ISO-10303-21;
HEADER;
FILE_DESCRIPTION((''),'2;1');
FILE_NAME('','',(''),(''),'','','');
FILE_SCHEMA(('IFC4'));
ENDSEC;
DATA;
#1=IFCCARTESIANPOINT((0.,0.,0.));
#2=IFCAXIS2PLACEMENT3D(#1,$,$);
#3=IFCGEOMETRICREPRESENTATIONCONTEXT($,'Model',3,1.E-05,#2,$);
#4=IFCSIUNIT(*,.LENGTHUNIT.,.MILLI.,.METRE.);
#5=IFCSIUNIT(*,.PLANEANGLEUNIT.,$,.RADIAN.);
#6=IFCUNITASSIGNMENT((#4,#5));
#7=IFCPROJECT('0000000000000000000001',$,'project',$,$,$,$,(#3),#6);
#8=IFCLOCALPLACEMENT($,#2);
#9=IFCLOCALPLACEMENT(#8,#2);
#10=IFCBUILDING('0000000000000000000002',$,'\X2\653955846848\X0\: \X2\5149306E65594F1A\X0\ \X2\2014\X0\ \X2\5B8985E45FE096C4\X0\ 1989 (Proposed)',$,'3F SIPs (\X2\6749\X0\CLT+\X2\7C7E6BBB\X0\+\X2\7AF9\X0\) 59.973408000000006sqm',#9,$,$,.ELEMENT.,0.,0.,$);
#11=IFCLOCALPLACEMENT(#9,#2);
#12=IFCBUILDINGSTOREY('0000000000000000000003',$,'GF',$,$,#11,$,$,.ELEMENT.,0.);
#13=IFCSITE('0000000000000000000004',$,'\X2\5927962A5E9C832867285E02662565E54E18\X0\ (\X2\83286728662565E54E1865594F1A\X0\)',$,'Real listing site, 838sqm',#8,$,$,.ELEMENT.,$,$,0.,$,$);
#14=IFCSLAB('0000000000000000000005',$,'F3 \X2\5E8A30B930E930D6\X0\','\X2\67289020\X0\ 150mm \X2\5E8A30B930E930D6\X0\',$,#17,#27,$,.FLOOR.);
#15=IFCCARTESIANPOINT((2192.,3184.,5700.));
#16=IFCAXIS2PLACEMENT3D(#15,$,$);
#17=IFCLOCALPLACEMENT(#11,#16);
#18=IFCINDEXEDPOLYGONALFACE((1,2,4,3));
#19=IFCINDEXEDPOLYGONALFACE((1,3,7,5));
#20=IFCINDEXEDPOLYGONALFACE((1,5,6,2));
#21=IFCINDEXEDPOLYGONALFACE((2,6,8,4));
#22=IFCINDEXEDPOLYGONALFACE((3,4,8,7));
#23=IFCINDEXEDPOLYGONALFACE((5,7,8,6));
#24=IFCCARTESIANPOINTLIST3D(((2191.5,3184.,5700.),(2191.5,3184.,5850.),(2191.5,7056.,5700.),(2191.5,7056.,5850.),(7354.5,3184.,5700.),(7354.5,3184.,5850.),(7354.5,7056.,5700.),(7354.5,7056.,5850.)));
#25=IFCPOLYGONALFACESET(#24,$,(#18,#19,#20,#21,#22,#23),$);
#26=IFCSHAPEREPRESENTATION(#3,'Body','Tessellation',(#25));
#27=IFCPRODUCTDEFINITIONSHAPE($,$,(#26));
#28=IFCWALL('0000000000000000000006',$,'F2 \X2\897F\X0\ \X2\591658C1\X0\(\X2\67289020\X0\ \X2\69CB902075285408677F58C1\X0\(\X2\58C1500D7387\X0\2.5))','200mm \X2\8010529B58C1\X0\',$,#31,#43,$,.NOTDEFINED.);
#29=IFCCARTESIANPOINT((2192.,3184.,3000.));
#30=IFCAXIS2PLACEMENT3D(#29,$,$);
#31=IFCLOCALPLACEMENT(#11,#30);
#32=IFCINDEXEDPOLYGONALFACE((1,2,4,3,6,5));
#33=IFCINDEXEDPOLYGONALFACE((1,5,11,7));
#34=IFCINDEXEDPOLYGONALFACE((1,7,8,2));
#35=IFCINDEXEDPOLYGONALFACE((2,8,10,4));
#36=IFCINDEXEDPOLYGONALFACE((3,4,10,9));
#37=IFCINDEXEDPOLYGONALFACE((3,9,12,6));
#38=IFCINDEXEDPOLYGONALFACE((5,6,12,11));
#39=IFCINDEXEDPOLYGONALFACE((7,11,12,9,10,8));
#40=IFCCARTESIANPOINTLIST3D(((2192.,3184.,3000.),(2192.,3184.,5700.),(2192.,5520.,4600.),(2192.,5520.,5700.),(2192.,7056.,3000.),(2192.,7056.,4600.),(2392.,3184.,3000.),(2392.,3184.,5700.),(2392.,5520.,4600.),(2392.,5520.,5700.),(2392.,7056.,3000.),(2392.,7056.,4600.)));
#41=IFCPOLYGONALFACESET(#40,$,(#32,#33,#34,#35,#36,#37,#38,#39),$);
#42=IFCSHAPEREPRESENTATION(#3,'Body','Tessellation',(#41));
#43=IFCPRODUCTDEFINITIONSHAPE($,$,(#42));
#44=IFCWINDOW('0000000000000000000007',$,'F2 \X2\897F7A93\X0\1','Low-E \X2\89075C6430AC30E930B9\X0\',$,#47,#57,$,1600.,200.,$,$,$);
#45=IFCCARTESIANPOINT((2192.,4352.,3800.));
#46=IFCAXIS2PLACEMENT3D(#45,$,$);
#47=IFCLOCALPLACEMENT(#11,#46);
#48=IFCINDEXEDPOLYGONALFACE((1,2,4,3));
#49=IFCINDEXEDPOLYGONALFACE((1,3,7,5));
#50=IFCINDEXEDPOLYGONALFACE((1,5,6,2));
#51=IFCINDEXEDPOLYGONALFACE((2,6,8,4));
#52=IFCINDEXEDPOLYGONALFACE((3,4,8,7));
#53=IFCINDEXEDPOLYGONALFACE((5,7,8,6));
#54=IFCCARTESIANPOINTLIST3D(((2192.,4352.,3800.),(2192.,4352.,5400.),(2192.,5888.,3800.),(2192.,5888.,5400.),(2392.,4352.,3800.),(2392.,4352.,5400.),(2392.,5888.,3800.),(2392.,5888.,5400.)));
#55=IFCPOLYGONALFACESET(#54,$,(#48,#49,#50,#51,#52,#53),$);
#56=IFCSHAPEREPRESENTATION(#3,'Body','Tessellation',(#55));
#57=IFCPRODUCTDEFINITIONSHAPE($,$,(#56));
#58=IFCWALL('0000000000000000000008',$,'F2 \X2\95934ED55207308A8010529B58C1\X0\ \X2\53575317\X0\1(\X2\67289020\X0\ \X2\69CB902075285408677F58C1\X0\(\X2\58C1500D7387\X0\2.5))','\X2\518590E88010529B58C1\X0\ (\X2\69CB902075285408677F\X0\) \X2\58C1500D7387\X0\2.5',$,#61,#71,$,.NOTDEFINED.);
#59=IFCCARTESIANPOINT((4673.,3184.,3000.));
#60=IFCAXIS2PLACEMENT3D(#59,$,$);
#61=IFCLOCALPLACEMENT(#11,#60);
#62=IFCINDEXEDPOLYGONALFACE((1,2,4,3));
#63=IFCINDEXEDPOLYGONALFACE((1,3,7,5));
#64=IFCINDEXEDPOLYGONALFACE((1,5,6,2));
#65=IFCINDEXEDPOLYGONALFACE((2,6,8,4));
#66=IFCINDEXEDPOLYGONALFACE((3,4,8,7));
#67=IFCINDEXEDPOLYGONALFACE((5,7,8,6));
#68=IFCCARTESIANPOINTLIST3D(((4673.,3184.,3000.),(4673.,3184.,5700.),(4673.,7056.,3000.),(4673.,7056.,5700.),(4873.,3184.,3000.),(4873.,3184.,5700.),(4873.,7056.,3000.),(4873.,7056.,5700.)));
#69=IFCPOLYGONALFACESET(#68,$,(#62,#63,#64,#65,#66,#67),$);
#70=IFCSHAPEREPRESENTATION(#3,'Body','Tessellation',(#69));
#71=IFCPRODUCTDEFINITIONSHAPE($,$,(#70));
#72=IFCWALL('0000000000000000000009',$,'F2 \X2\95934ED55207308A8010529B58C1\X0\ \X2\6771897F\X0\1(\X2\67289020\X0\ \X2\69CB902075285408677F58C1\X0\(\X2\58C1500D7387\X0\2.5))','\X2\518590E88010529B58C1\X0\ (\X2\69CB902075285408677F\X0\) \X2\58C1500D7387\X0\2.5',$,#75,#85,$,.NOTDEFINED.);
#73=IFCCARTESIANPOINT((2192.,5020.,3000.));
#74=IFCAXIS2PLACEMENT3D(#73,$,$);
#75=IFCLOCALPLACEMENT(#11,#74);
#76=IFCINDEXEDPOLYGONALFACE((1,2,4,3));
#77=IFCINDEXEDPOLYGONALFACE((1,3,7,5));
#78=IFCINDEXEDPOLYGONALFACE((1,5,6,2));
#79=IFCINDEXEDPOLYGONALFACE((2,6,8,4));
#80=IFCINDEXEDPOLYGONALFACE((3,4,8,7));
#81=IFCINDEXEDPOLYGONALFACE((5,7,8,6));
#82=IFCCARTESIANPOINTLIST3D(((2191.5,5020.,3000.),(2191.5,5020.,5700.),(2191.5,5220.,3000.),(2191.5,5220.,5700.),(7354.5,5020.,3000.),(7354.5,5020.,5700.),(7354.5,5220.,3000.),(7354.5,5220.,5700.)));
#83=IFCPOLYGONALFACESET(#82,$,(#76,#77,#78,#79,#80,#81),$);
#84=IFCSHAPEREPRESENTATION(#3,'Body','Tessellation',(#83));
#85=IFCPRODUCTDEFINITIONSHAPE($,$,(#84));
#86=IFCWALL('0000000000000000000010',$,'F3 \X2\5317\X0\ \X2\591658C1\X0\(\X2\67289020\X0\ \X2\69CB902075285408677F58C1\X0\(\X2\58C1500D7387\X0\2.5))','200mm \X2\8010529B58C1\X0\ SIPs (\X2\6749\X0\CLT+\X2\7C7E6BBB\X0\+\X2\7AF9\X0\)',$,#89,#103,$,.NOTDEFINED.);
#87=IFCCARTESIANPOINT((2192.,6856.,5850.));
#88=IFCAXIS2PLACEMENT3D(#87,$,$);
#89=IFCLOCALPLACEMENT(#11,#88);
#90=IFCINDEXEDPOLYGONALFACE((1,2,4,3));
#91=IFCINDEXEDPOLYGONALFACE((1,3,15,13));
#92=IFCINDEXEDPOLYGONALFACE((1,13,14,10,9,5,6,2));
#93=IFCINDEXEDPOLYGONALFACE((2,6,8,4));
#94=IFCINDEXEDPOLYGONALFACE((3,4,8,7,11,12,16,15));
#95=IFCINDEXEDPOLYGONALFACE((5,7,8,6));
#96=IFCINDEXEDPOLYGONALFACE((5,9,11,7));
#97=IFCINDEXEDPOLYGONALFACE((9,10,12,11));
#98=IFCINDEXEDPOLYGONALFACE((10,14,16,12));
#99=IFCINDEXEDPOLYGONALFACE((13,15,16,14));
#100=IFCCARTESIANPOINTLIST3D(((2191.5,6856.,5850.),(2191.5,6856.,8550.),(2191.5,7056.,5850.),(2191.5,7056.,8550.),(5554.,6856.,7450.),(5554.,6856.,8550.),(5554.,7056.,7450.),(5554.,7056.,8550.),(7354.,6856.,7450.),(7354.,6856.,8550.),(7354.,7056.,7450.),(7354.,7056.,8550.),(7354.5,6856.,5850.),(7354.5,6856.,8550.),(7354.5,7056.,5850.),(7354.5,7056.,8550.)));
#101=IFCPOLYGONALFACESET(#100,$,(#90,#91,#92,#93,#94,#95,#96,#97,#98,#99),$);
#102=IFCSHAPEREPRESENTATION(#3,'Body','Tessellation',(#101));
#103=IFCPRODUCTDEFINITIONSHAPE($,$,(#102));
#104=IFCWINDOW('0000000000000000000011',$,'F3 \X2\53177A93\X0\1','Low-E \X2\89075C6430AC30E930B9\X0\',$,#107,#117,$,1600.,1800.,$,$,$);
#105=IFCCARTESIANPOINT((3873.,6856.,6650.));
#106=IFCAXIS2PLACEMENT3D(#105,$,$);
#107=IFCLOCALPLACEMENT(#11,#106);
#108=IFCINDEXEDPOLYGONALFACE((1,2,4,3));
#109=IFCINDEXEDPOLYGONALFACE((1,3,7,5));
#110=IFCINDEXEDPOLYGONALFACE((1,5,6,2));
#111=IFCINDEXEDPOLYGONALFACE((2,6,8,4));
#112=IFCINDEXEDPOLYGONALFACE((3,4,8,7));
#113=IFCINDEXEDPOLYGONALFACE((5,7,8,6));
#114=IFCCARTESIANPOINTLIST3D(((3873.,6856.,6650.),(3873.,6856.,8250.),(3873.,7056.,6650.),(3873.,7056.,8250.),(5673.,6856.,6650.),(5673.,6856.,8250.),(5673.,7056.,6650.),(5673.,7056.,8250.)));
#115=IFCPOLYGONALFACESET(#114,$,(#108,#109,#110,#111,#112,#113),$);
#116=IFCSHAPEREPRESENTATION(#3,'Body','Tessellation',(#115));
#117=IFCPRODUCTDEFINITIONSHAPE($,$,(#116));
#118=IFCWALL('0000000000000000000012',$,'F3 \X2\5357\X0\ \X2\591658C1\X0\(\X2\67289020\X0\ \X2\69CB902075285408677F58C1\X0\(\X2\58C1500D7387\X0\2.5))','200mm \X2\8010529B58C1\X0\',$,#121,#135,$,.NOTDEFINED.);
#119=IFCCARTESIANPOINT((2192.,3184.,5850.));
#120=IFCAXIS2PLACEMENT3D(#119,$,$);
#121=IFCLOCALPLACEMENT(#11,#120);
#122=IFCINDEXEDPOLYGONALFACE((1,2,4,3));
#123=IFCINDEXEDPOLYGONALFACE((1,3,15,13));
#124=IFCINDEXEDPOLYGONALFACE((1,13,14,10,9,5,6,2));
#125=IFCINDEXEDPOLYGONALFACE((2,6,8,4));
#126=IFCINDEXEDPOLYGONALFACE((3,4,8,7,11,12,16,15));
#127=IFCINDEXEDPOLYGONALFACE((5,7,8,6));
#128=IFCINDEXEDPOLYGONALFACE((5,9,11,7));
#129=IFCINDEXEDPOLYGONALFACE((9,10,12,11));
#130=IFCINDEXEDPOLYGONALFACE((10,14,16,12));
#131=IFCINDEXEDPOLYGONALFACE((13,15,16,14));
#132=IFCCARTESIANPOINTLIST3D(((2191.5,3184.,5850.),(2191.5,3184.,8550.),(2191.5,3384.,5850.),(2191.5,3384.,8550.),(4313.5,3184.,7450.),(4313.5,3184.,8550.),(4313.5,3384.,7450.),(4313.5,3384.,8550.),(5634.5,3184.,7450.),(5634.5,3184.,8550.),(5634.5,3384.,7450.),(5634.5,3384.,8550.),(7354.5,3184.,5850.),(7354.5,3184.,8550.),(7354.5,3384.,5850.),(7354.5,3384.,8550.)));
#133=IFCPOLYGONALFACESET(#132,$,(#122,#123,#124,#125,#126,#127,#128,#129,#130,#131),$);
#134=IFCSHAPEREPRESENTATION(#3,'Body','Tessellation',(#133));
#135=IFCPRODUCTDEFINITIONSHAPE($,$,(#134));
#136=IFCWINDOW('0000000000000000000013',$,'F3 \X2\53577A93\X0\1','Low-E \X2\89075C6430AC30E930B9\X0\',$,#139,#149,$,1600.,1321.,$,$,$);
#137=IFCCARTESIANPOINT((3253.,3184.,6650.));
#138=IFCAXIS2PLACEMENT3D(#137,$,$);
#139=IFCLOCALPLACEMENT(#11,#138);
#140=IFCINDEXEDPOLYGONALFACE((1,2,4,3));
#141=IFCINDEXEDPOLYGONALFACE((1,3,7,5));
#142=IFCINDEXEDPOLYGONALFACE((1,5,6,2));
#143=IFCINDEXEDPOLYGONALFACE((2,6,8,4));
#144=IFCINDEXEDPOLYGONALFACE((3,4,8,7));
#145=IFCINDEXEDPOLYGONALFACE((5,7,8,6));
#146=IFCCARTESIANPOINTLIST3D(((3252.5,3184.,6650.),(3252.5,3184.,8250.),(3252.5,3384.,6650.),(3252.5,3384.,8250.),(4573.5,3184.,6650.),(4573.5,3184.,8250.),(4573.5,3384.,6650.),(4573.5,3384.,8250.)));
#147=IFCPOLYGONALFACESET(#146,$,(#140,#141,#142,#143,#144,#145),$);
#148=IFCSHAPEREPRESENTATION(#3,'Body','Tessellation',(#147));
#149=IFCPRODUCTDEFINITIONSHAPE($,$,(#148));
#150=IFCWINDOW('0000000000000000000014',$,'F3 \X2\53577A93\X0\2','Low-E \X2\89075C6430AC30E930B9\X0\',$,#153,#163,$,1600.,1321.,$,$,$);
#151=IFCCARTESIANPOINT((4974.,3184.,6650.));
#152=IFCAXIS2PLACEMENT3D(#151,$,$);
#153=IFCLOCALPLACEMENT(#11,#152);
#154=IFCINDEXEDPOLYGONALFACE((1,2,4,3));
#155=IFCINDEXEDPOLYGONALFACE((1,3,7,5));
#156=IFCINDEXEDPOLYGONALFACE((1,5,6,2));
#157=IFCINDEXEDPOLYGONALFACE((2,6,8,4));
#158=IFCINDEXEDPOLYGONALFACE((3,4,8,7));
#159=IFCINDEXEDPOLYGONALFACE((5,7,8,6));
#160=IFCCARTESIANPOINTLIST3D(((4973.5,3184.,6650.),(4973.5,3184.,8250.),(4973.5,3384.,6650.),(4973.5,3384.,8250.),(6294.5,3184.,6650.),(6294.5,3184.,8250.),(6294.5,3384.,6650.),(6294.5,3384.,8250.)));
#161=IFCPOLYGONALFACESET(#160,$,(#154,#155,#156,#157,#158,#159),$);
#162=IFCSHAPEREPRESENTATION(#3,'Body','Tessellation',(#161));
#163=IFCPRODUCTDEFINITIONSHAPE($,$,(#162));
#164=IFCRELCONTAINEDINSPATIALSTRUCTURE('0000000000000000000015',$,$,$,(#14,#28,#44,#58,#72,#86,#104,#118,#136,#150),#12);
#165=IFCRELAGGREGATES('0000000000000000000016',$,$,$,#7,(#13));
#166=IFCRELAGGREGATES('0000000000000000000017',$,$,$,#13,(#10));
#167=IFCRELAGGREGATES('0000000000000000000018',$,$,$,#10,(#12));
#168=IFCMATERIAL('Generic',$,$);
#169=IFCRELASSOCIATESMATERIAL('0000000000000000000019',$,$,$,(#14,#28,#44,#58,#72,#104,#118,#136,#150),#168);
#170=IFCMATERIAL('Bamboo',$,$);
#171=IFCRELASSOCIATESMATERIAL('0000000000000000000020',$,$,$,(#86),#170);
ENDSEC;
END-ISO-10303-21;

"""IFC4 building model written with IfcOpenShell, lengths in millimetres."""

from ifc_helpers import new_model, si_unit, frame, frame_2d, origin, place, context, project, spatial, rectangle, extrude, material, element, fill, save


model = new_model("IFC4")

# Units and contexts
model_context = context("Model", 3, precision=1e-05, world=origin())
ifc_project = project(units=[si_unit("LENGTHUNIT", "METRE", prefix="MILLI"), si_unit("PLANEANGLEUNIT", "RADIAN")], contexts=[model_context])

# Site, building, storey
site_placement = place(None, origin())
site = spatial("IfcSite", under=ifc_project, at=site_placement, Name="大阪府茨木市春日丘 (茨木春日丘教会)", ObjectType="Real listing site, 838sqm", CompositionType="ELEMENT", RefElevation=0.0)
building_placement = place(site_placement, origin())
building = spatial("IfcBuilding", under=site, at=building_placement, Name="改善案: 光の教会 — 安藤忠雄 1989 (Proposed)", ObjectType="3F SIPs (杉CLT+籾殻+竹) 59.973408000000006sqm", CompositionType="ELEMENT", ElevationOfRefHeight=0.0, ElevationOfTerrain=0.0)
storey_placement = place(building_placement, origin())
storey = spatial("IfcBuildingStorey", under=building, at=storey_placement, Name="GF", CompositionType="ELEMENT", Elevation=0.0)

# Slab
ifc_material_1 = material(Name="Generic")
slab_placement = place(storey_placement, frame((2192.0, 3184.0, 5700.0)))
element("IfcSlab", 1, at=slab_placement, inside=storey, material=ifc_material_1, Name="F3 床スラブ", Description="木造 150mm 床スラブ", PredefinedType="FLOOR", context=model_context, shape_type="SweptSolid", body=[
    extrude(rectangle(XDim=5163.0, YDim=3872.0, at=frame_2d((2581.0, 1936.0))), frame((2192.0, 3184.0, 5700.0)), (0.0, 0.0, 1.0), 150.0),
])

# Wall, opening, window
wall_1_placement = place(storey_placement, frame((2192.0, 3184.0, 3000.0)))
wall_1 = element("IfcWall", 2, at=wall_1_placement, inside=storey, material=ifc_material_1, Name="F2 西 外壁(木造 構造用合板壁(壁倍率2.5))", Description="200mm 耐力壁", PredefinedType="NOTDEFINED", context=model_context, shape_type="SweptSolid", body=[
    extrude(rectangle(XDim=200.0, YDim=3872.0, at=frame_2d((100.0, 1936.0))), frame((2192.0, 3184.0, 3000.0)), (0.0, 0.0, 1.0), 2700.0),
])
opening_1_placement = place(storey_placement, frame((2192.0, 4352.0, 3800.0)))
opening_1 = element("IfcOpeningElement", 3, at=opening_1_placement, cuts=wall_1, PredefinedType="NOTDEFINED", context=model_context, shape_type="SweptSolid", body=[
    extrude(rectangle(XDim=200.0, YDim=1536.0, at=frame_2d((100.0, 768.0))), frame((2192.0, 4352.0, 3800.0)), (0.0, 0.0, 1.0), 1600.0),
])
window_1_placement = place(storey_placement, frame((2192.0, 4352.0, 3800.0)))
window_1 = element("IfcWindow", 4, at=window_1_placement, inside=storey, material=ifc_material_1, Name="F2 西窓1", Description="Low-E 複層ガラス", OverallHeight=1600.0, OverallWidth=200.0, context=model_context, shape_type="SweptSolid", body=[
    extrude(rectangle(XDim=200.0, YDim=1536.0, at=frame_2d((100.0, 768.0))), frame((2192.0, 4352.0, 3800.0)), (0.0, 0.0, 1.0), 1600.0),
])
fill(opening_1, window_1)

# Walls
wall_2_placement = place(storey_placement, frame((4673.0, 3184.0, 3000.0)))
element("IfcWall", 5, at=wall_2_placement, inside=storey, material=ifc_material_1, Name="F2 間仕切り耐力壁 南北1(木造 構造用合板壁(壁倍率2.5))", Description="内部耐力壁 (構造用合板) 壁倍率2.5", PredefinedType="NOTDEFINED", context=model_context, shape_type="SweptSolid", body=[
    extrude(rectangle(XDim=200.0, YDim=3872.0, at=frame_2d((100.0, 1936.0))), frame((4673.0, 3184.0, 3000.0)), (0.0, 0.0, 1.0), 2700.0),
])
wall_3_placement = place(storey_placement, frame((2192.0, 5020.0, 3000.0)))
element("IfcWall", 6, at=wall_3_placement, inside=storey, material=ifc_material_1, Name="F2 間仕切り耐力壁 東西1(木造 構造用合板壁(壁倍率2.5))", Description="内部耐力壁 (構造用合板) 壁倍率2.5", PredefinedType="NOTDEFINED", context=model_context, shape_type="SweptSolid", body=[
    extrude(rectangle(XDim=5163.0, YDim=200.0, at=frame_2d((2581.0, 100.0))), frame((2192.0, 5020.0, 3000.0)), (0.0, 0.0, 1.0), 2700.0),
])

# Wall, opening, window
ifc_material_2 = material(Name="Bamboo")
wall_4_placement = place(storey_placement, frame((2192.0, 6856.0, 5850.0)))
wall_4 = element("IfcWall", 7, at=wall_4_placement, inside=storey, material=ifc_material_2, Name="F3 北 外壁(木造 構造用合板壁(壁倍率2.5))", Description="200mm 耐力壁 SIPs (杉CLT+籾殻+竹)", PredefinedType="NOTDEFINED", context=model_context, shape_type="SweptSolid", body=[
    extrude(rectangle(XDim=5163.0, YDim=200.0, at=frame_2d((2581.0, 100.0))), frame((2192.0, 6856.0, 5850.0)), (0.0, 0.0, 1.0), 2700.0),
])
opening_2_placement = place(storey_placement, frame((3873.0, 6856.0, 6650.0)))
opening_2 = element("IfcOpeningElement", 8, at=opening_2_placement, cuts=wall_4, PredefinedType="NOTDEFINED", context=model_context, shape_type="SweptSolid", body=[
    extrude(rectangle(XDim=1800.0, YDim=200.0, at=frame_2d((900.0, 100.0))), frame((3873.0, 6856.0, 6650.0)), (0.0, 0.0, 1.0), 1600.0),
])
window_2_placement = place(storey_placement, frame((3873.0, 6856.0, 6650.0)))
window_2 = element("IfcWindow", 9, at=window_2_placement, inside=storey, material=ifc_material_1, Name="F3 北窓1", Description="Low-E 複層ガラス", OverallHeight=1600.0, OverallWidth=1800.0, context=model_context, shape_type="SweptSolid", body=[
    extrude(rectangle(XDim=1800.0, YDim=200.0, at=frame_2d((900.0, 100.0))), frame((3873.0, 6856.0, 6650.0)), (0.0, 0.0, 1.0), 1600.0),
])
fill(opening_2, window_2)

# Wall, openings, windows
wall_5_placement = place(storey_placement, frame((2192.0, 3184.0, 5850.0)))
wall_5 = element("IfcWall", 10, at=wall_5_placement, inside=storey, material=ifc_material_1, Name="F3 南 外壁(木造 構造用合板壁(壁倍率2.5))", Description="200mm 耐力壁", PredefinedType="NOTDEFINED", context=model_context, shape_type="SweptSolid", body=[
    extrude(rectangle(XDim=5163.0, YDim=200.0, at=frame_2d((2581.0, 100.0))), frame((2192.0, 3184.0, 5850.0)), (0.0, 0.0, 1.0), 2700.0),
])
opening_3_placement = place(storey_placement, frame((3253.0, 3184.0, 6650.0)))
opening_3 = element("IfcOpeningElement", 11, at=opening_3_placement, cuts=wall_5, PredefinedType="NOTDEFINED", context=model_context, shape_type="SweptSolid", body=[
    extrude(rectangle(XDim=1321.0, YDim=200.0, at=frame_2d((660.0, 100.0))), frame((3253.0, 3184.0, 6650.0)), (0.0, 0.0, 1.0), 1600.0),
])
opening_4_placement = place(storey_placement, frame((4974.0, 3184.0, 6650.0)))
opening_4 = element("IfcOpeningElement", 12, at=opening_4_placement, cuts=wall_5, PredefinedType="NOTDEFINED", context=model_context, shape_type="SweptSolid", body=[
    extrude(rectangle(XDim=1321.0, YDim=200.0, at=frame_2d((660.0, 100.0))), frame((4974.0, 3184.0, 6650.0)), (0.0, 0.0, 1.0), 1600.0),
])
window_3_placement = place(storey_placement, frame((3253.0, 3184.0, 6650.0)))
window_3 = element("IfcWindow", 13, at=window_3_placement, inside=storey, material=ifc_material_1, Name="F3 南窓1", Description="Low-E 複層ガラス", OverallHeight=1600.0, OverallWidth=1321.0, context=model_context, shape_type="SweptSolid", body=[
    extrude(rectangle(XDim=1321.0, YDim=200.0, at=frame_2d((660.0, 100.0))), frame((3253.0, 3184.0, 6650.0)), (0.0, 0.0, 1.0), 1600.0),
])
fill(opening_3, window_3)
window_4_placement = place(storey_placement, frame((4974.0, 3184.0, 6650.0)))
window_4 = element("IfcWindow", 14, at=window_4_placement, inside=storey, material=ifc_material_1, Name="F3 南窓2", Description="Low-E 複層ガラス", OverallHeight=1600.0, OverallWidth=1321.0, context=model_context, shape_type="SweptSolid", body=[
    extrude(rectangle(XDim=1321.0, YDim=200.0, at=frame_2d((660.0, 100.0))), frame((4974.0, 3184.0, 6650.0)), (0.0, 0.0, 1.0), 1600.0),
])
fill(opening_4, window_4)

save(model, "model.ifc")
